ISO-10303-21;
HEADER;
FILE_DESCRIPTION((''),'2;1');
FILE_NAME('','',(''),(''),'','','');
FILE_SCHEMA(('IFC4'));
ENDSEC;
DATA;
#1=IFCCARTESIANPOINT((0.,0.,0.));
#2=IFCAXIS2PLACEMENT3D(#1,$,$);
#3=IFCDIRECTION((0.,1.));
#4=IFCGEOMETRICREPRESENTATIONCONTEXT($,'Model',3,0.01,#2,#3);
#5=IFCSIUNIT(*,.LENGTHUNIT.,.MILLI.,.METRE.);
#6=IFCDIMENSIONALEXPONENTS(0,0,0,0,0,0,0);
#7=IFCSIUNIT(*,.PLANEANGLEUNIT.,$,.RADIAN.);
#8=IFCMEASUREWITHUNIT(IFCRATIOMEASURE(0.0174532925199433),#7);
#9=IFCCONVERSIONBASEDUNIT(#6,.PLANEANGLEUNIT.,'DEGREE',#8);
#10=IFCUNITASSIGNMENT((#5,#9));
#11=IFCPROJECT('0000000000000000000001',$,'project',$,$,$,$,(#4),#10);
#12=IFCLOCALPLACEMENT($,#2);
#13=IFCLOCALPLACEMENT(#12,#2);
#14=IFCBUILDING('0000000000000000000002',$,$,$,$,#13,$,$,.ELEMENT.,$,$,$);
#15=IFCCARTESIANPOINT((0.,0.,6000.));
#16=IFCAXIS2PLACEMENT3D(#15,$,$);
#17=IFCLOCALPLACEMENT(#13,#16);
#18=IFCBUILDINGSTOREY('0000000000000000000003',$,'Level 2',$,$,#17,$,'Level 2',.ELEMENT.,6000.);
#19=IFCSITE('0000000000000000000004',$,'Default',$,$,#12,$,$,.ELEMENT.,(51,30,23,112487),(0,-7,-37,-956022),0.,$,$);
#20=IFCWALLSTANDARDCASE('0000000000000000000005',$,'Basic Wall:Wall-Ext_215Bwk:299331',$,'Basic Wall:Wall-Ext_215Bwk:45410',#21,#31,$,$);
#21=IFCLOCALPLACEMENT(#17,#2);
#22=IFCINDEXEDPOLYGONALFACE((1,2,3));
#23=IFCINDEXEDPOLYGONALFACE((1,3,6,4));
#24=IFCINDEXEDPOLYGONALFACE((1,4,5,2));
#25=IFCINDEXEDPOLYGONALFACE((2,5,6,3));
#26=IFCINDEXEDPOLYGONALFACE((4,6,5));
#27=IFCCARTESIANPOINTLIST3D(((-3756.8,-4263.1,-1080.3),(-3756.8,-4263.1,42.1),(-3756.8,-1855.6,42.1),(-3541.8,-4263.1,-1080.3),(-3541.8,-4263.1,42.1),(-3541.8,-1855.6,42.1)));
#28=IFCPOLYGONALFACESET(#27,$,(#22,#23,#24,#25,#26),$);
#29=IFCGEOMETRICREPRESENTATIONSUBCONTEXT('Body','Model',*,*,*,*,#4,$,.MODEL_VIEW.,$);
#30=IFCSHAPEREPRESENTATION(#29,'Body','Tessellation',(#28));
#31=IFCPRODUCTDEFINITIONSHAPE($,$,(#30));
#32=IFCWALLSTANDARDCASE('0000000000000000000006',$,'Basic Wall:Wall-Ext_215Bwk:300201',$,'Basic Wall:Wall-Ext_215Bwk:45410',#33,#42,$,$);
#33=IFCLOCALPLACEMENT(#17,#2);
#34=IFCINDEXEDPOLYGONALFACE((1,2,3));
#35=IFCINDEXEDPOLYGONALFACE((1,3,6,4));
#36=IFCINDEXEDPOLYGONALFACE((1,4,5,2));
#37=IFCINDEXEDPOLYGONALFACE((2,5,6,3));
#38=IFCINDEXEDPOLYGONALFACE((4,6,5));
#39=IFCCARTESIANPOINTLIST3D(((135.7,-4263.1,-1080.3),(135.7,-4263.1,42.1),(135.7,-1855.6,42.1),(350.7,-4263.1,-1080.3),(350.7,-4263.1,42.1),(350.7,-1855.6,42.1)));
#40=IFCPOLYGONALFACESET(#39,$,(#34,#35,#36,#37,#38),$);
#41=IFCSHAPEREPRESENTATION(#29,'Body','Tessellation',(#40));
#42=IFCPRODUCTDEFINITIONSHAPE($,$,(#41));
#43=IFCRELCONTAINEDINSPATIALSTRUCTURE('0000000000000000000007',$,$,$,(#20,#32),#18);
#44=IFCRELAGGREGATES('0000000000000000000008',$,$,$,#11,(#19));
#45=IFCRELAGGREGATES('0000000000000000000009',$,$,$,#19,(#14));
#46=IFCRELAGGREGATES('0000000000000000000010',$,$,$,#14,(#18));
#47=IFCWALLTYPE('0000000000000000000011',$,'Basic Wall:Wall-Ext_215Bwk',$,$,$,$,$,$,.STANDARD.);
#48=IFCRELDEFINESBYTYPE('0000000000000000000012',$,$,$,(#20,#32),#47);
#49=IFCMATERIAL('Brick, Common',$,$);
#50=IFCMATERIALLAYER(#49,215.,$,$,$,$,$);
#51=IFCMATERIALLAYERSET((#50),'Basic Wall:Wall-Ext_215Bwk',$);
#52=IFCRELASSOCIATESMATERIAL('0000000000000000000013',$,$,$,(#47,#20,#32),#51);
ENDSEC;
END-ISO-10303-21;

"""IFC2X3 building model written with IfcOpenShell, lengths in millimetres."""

from ifc_helpers import new_model, entity, si_unit, converted_unit, direction, frame, frame_2d, origin, place, context, subcontext, project, spatial, rectangle, extrude, clip, halfspace, material, layer, layer_set, layer_usage, type_object, element, save


model = new_model("IFC2X3")

# Units and contexts
model_context = context("Model", 3, precision=0.01, world=origin(), true_north=direction((0.0, 1.0)))
body_context = subcontext(model_context, "Body", "Model", "MODEL_VIEW")
ifc_project = project(units=[si_unit("LENGTHUNIT", "METRE", prefix="MILLI"), converted_unit("PLANEANGLEUNIT", "DEGREE", entity("IfcRatioMeasure", 0.0174532925199433), si_unit("PLANEANGLEUNIT", "RADIAN"), dimensions=[0, 0, 0, 0, 0, 0, 0])], contexts=[model_context])

# Site, building, storey
site_placement = place(None, origin())
site = spatial("IfcSite", under=ifc_project, at=site_placement, Name="Default", CompositionType="ELEMENT", RefLatitude=(51, 30, 23, 112487), RefLongitude=(0, -7, -37, -956022), RefElevation=0.0)
building_placement = place(site_placement, origin())
building = spatial("IfcBuilding", under=site, at=building_placement, CompositionType="ELEMENT")
storey_placement = place(building_placement, frame((0.0, 0.0, 6000.0)))
storey = spatial("IfcBuildingStorey", under=building, at=storey_placement, Name="Level 2", LongName="Level 2", CompositionType="ELEMENT", Elevation=6000.0)

# Wall
ifc_material = material(Name="Brick, Common")
ifc_layer = layer(ifc_material, 215.0)
ifc_layer_set = layer_set([ifc_layer], Name="Basic Wall:Wall-Ext_215Bwk")
ifc_layer_usage_1 = layer_usage(ifc_layer_set, "AXIS2", "NEGATIVE", 107.5)
wall_type = type_object("IfcWallType", Name="Basic Wall:Wall-Ext_215Bwk", PredefinedType="STANDARD", material=ifc_layer_set)
wall_1_placement = place(storey_placement, frame((-3649.3, -1855.6, -1080.3), z_axis=(0.0, 0.0, 1.0), x_axis=(0.0, -1.0, 0.0)))
element("IfcWallStandardCase", 1, at=wall_1_placement, inside=storey, type_object=wall_type, material=ifc_layer_usage_1, Name="Basic Wall:Wall-Ext_215Bwk:299331", ObjectType="Basic Wall:Wall-Ext_215Bwk:45410", context=body_context, shape_type="Clipping", body=[
    clip(extrude(rectangle(XDim=2407.5, YDim=215.0, at=frame_2d((1203.8, 0.0), x_axis=(-1.0, 0.0))), origin(), (0.0, 0.0, 1.0), 1122.4), halfspace(frame((2407.5, -107.5, 0.0), z_axis=(-0.422538, 0.0, -0.906345), x_axis=(0.0, 1.0, 0.0)), False)),
])

# Wall
ifc_layer_usage_2 = layer_usage(ifc_layer_set, "AXIS2", "NEGATIVE", 107.5)
wall_2_placement = place(storey_placement, frame((243.2, -1855.6, -1080.3), z_axis=(0.0, 0.0, 1.0), x_axis=(0.0, -1.0, 0.0)))
element("IfcWallStandardCase", 2, at=wall_2_placement, inside=storey, type_object=wall_type, material=ifc_layer_usage_2, Name="Basic Wall:Wall-Ext_215Bwk:300201", ObjectType="Basic Wall:Wall-Ext_215Bwk:45410", context=body_context, shape_type="Clipping", body=[
    clip(extrude(rectangle(XDim=2407.5, YDim=215.0, at=frame_2d((1203.8, 0.0), x_axis=(-1.0, 0.0))), origin(), (0.0, 0.0, 1.0), 1122.4), halfspace(frame((2407.5, -107.5, 0.0), z_axis=(-0.422538, 0.0, -0.906345), x_axis=(0.0, 1.0, 0.0)), False)),
])

save(model, "model.ifc")
